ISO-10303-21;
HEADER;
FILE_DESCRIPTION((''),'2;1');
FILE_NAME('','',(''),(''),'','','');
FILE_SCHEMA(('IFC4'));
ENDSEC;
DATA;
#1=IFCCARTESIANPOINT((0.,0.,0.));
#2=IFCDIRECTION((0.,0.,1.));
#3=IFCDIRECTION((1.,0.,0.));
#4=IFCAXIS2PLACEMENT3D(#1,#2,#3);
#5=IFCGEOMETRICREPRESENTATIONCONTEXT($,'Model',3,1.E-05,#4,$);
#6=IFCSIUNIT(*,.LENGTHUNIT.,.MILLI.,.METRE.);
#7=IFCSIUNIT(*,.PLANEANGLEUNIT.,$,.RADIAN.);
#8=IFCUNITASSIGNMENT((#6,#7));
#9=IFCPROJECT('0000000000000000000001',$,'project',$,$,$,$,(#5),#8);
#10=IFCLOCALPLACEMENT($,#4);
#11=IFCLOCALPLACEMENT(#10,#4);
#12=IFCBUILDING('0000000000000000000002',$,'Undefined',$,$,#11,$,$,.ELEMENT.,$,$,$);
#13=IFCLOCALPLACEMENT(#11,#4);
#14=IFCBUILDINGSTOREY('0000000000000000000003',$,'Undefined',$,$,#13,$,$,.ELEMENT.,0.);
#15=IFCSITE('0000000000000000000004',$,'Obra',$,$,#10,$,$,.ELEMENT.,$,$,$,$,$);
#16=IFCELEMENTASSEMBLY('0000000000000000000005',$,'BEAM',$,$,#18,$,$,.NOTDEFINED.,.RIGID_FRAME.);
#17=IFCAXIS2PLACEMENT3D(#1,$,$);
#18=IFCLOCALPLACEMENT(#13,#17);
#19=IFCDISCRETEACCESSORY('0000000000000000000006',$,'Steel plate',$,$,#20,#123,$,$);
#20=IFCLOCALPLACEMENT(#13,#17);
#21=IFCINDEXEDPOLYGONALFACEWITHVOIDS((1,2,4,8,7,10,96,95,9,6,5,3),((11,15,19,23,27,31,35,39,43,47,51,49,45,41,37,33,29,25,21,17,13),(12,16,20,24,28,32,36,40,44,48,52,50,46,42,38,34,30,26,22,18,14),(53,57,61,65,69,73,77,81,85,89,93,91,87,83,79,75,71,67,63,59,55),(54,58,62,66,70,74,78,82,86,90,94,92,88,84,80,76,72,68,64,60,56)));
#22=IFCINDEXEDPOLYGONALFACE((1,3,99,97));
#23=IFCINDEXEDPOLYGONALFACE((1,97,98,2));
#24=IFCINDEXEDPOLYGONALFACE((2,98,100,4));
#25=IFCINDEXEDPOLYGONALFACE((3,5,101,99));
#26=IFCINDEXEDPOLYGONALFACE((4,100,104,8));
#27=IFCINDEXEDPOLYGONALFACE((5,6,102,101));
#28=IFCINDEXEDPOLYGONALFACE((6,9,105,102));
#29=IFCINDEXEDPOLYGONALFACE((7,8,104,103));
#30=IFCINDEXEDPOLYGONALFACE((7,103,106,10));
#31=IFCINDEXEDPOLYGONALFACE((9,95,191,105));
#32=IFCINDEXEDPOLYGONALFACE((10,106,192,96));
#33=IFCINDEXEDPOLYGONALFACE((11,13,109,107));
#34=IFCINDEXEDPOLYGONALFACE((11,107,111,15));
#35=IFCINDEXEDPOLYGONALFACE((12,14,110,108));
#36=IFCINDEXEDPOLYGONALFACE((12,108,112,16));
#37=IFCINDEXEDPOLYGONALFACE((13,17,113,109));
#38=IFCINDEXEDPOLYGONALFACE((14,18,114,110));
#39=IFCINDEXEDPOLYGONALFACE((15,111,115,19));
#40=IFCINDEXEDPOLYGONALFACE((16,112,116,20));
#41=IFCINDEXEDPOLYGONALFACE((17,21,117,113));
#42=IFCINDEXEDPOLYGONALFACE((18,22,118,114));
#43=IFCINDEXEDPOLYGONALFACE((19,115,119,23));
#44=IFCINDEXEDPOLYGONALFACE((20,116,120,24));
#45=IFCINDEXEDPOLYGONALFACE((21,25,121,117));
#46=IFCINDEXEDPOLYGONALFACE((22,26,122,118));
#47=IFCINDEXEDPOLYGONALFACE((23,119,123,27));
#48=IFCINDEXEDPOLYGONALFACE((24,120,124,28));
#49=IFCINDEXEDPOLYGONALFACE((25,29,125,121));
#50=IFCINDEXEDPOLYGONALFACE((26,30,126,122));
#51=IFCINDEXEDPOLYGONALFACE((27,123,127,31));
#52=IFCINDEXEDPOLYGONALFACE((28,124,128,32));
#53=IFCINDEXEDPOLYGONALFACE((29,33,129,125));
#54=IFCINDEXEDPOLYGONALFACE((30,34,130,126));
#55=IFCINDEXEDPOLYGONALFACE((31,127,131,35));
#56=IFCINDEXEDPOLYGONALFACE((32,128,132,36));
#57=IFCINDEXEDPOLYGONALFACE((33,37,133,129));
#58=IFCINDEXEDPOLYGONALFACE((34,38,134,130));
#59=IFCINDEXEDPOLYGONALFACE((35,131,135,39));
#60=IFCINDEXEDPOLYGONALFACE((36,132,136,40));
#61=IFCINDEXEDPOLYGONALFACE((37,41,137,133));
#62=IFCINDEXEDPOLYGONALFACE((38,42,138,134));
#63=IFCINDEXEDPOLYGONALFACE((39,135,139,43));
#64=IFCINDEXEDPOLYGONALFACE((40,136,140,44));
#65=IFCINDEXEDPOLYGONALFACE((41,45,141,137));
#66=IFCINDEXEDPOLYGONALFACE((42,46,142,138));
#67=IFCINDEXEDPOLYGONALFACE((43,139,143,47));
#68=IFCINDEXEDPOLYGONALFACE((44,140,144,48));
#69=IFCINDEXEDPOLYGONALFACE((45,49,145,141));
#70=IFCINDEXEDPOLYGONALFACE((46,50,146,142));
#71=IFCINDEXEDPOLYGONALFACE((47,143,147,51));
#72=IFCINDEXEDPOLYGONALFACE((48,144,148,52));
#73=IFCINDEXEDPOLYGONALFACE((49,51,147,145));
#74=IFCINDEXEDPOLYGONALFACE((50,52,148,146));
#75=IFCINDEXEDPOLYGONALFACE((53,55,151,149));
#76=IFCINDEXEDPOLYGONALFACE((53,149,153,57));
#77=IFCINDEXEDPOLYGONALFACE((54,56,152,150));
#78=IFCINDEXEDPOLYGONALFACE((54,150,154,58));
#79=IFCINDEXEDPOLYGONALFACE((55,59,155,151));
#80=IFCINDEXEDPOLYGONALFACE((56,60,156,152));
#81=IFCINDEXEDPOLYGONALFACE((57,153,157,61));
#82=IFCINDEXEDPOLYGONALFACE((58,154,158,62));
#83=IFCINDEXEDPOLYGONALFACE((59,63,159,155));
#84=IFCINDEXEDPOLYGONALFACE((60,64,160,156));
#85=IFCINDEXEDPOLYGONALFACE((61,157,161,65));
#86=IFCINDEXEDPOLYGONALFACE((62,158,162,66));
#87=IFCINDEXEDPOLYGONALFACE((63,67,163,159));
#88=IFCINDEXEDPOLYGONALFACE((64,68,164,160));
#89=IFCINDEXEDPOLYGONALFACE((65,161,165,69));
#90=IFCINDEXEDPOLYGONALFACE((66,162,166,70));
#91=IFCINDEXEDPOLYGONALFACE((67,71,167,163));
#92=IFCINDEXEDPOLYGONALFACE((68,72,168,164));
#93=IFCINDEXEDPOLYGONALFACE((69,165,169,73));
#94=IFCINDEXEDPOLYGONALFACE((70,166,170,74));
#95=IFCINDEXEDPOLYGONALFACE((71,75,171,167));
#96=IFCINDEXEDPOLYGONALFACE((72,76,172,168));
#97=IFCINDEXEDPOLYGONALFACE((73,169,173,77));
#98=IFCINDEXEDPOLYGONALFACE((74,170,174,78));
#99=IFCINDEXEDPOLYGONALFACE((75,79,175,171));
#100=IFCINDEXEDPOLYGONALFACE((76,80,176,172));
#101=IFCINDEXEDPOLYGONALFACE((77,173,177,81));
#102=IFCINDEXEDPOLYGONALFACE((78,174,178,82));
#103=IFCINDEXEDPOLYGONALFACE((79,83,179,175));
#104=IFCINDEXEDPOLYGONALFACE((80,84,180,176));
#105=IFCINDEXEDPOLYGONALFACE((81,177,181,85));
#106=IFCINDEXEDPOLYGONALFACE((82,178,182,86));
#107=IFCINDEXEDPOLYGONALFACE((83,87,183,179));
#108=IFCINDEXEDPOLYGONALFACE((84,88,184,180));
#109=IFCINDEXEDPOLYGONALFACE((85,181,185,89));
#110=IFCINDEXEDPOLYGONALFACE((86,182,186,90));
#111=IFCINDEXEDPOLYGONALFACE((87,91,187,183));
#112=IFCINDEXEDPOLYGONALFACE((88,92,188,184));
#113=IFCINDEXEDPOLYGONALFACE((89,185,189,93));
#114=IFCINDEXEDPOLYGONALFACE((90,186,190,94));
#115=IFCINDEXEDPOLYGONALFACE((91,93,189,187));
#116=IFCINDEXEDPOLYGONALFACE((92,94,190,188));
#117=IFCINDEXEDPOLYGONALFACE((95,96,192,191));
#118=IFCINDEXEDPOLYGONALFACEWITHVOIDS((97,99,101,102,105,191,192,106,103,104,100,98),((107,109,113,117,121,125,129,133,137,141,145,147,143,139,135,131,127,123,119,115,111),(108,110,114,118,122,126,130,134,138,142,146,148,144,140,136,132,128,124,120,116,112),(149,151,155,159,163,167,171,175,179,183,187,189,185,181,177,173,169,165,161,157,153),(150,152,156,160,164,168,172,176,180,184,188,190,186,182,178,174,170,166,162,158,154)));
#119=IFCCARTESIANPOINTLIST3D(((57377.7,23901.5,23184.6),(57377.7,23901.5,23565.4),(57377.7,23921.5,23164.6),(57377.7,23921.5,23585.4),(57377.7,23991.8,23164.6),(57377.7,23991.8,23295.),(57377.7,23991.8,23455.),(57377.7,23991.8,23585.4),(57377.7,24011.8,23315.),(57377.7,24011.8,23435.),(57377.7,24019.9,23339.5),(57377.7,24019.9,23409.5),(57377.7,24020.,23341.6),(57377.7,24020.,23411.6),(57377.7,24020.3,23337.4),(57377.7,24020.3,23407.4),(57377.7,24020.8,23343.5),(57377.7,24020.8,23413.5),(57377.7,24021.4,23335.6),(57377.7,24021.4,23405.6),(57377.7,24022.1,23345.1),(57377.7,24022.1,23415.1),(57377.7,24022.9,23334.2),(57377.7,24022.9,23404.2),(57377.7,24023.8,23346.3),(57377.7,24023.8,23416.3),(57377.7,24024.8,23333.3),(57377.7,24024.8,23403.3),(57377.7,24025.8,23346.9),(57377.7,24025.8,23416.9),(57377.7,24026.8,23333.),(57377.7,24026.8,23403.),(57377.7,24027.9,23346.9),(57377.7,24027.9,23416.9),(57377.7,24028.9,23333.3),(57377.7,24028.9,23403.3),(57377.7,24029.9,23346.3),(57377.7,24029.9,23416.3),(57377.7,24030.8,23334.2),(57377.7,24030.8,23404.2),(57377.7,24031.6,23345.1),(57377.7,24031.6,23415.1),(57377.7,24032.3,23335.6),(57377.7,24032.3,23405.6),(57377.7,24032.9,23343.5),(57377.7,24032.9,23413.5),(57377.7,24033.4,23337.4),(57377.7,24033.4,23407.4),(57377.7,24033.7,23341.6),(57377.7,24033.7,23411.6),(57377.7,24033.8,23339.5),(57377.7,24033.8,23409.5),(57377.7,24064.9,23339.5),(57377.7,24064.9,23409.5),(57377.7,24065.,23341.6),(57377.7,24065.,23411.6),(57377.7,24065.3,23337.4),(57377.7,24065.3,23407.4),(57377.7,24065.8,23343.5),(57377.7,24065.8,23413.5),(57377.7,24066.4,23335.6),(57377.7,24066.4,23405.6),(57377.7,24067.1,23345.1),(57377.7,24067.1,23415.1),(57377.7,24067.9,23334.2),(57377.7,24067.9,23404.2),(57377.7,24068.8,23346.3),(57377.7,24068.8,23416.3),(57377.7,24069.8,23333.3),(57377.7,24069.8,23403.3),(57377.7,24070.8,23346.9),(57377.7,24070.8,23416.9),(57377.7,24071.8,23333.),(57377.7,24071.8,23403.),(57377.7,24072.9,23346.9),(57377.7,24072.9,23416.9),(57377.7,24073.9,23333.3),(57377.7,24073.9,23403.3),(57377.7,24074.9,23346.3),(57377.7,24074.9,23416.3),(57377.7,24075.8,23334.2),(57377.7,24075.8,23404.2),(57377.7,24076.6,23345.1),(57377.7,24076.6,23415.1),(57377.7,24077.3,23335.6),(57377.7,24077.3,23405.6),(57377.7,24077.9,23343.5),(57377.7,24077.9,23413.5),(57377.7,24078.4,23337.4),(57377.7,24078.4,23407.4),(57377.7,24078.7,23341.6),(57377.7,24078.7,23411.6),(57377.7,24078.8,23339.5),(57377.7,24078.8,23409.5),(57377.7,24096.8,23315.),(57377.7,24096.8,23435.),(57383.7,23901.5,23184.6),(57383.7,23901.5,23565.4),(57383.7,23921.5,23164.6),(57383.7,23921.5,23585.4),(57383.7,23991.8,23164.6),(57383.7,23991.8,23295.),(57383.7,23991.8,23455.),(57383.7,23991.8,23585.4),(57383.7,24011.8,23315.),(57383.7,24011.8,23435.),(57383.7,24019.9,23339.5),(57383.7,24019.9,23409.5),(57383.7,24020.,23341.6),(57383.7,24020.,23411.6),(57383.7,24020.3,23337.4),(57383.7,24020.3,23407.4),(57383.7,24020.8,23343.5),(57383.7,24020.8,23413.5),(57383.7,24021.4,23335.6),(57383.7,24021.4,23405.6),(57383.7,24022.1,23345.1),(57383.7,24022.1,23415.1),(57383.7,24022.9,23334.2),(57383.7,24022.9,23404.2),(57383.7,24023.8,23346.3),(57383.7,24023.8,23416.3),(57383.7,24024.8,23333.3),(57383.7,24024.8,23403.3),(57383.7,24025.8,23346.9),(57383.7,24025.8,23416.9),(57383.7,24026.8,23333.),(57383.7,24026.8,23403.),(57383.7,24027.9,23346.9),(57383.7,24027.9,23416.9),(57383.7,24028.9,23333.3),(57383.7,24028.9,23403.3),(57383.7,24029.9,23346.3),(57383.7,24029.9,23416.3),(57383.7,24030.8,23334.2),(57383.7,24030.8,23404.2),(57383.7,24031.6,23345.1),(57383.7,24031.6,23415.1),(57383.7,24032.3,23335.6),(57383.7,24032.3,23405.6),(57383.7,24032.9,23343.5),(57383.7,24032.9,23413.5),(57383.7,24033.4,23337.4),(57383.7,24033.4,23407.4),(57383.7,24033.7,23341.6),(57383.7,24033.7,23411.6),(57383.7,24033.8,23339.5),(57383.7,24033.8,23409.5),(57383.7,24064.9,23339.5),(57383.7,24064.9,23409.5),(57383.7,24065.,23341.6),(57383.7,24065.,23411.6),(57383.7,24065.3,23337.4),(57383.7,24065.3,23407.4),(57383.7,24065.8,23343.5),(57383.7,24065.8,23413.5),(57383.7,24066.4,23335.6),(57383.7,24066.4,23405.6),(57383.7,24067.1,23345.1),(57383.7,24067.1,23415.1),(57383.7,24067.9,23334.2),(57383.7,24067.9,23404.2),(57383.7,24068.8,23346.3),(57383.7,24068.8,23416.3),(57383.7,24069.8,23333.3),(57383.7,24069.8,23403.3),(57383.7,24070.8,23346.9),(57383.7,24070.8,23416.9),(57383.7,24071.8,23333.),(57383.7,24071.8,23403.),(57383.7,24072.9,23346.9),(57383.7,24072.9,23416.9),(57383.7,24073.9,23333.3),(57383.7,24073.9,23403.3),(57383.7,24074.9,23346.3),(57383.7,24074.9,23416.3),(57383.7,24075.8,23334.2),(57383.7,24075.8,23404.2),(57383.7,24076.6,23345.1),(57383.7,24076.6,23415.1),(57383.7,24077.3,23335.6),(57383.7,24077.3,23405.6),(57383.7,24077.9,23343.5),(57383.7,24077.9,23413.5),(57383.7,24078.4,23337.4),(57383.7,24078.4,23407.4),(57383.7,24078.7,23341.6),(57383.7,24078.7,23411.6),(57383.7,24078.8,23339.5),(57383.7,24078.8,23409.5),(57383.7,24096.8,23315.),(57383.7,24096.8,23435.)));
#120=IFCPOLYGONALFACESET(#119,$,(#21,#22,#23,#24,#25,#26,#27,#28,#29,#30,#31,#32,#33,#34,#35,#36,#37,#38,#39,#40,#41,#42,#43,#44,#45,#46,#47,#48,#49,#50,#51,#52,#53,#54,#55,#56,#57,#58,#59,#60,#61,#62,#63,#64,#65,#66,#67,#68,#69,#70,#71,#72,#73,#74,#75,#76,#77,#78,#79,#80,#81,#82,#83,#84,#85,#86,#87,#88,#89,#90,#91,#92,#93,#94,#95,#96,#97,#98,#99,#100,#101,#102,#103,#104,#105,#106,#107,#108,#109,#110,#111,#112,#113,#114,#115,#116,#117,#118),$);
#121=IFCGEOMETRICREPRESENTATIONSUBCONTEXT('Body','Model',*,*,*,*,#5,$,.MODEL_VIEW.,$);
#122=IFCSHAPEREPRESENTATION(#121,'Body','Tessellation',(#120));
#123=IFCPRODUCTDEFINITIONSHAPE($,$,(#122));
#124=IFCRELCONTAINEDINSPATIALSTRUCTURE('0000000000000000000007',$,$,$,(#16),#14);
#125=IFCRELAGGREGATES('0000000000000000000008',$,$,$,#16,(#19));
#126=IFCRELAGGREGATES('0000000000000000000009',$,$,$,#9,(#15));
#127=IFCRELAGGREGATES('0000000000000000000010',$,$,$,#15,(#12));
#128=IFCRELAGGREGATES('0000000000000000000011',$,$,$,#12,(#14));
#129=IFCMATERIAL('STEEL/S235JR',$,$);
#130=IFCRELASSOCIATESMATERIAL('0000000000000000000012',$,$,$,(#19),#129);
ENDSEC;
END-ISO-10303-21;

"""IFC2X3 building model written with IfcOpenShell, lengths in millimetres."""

from ifc_helpers import new_model, si_unit, frame, origin_with_axes, origin_2d_with_axis, place, context, subcontext, project, spatial, polyline, circle, outline, extrude, source, transform, mapped, material, element, aggregate, save


model = new_model("IFC2X3")

# Units and contexts
model_context = context("Model", 3, precision=1e-05, world=origin_with_axes())
body_context = subcontext(model_context, "Body", "Model", "MODEL_VIEW")
ifc_project = project(units=[si_unit("LENGTHUNIT", "METRE", prefix="MILLI"), si_unit("PLANEANGLEUNIT", "RADIAN")], contexts=[model_context])

# Site, building, storey
site_placement = place(None, origin_with_axes())
site = spatial("IfcSite", under=ifc_project, at=site_placement, Name="Obra", CompositionType="ELEMENT")
building_placement = place(site_placement, origin_with_axes())
building = spatial("IfcBuilding", under=site, at=building_placement, Name="Undefined", CompositionType="ELEMENT")
storey_placement = place(building_placement, origin_with_axes())
storey = spatial("IfcBuildingStorey", under=building, at=storey_placement, Name="Undefined", CompositionType="ELEMENT", Elevation=0.0)

# Shared definitions
ifc_material_1 = material(Name="STEEL/S235JR")

# Element assembly, discrete accessory, opening
assembly_1_placement = place(storey_placement, origin_with_axes())
assembly_1 = element("IfcElementAssembly", 1, at=assembly_1_placement, inside=storey, Name="BEAM", AssemblyPlace="NOTDEFINED", PredefinedType="RIGID_FRAME")
discrete_accessory_1_placement = place(assembly_1_placement, frame((57380.7, 23901.5, 23184.6), z_axis=(1.0, 0.0, 0.0), x_axis=(0.0, 0.707107, -0.707107)))
discrete_accessory_1 = element("IfcDiscreteAccessory", 2, at=discrete_accessory_1_placement, material=ifc_material_1, Name="Steel plate", context=body_context, shape_type="SweptSolid", body=[
    extrude(outline(polyline([(0.0, 0.0), (28.3, 0.0), (78.0, 49.7), (-14.2, 141.9), (-14.2, 170.2), (45.9, 230.3), (-39.0, 315.2), (-99.1, 255.1), (-127.3, 255.1), (-219.6, 347.3), (-269.3, 297.6), (-269.3, 269.3), (0.0, 0.0)])), frame((0.0, 0.0, -3.0), z_axis=(0.0, 0.0, 1.0), x_axis=(1.0, 0.0, 0.0)), (0.0, 0.0, 1.0), 6.0),
])
shared_shape_1 = source(origin_with_axes(), body_context, "Body", "SweptSolid", [
    extrude(circle(Radius=7.0, at=origin_2d_with_axis()), frame((0.0, -8.6, 0.0), z_axis=(0.0, 1.0, 0.0), x_axis=(1.0, 0.0, 0.0)), (0.0, 0.0, 1.0), 6.2),
])
opening_1_placement = place(assembly_1_placement, frame((57375.2, 24001.8, 23435.0), z_axis=(0.0, 1.0, 0.0), x_axis=(0.0, 0.0, -1.0)))
element("IfcOpeningElement", 3, at=opening_1_placement, cuts=discrete_accessory_1, ObjectType="Opening", context=body_context, shape_type="MappedRepresentation", body=[
    mapped(shared_shape_1, transform((25.0, 0.0, 25.0))),
    mapped(shared_shape_1, transform((25.0, 0.0, 70.0))),
    mapped(shared_shape_1, transform((95.0, 0.0, 25.0))),
    mapped(shared_shape_1, transform((95.0, 0.0, 70.0))),
])

aggregate(assembly_1, [discrete_accessory_1])

save(model, "model.ifc")
